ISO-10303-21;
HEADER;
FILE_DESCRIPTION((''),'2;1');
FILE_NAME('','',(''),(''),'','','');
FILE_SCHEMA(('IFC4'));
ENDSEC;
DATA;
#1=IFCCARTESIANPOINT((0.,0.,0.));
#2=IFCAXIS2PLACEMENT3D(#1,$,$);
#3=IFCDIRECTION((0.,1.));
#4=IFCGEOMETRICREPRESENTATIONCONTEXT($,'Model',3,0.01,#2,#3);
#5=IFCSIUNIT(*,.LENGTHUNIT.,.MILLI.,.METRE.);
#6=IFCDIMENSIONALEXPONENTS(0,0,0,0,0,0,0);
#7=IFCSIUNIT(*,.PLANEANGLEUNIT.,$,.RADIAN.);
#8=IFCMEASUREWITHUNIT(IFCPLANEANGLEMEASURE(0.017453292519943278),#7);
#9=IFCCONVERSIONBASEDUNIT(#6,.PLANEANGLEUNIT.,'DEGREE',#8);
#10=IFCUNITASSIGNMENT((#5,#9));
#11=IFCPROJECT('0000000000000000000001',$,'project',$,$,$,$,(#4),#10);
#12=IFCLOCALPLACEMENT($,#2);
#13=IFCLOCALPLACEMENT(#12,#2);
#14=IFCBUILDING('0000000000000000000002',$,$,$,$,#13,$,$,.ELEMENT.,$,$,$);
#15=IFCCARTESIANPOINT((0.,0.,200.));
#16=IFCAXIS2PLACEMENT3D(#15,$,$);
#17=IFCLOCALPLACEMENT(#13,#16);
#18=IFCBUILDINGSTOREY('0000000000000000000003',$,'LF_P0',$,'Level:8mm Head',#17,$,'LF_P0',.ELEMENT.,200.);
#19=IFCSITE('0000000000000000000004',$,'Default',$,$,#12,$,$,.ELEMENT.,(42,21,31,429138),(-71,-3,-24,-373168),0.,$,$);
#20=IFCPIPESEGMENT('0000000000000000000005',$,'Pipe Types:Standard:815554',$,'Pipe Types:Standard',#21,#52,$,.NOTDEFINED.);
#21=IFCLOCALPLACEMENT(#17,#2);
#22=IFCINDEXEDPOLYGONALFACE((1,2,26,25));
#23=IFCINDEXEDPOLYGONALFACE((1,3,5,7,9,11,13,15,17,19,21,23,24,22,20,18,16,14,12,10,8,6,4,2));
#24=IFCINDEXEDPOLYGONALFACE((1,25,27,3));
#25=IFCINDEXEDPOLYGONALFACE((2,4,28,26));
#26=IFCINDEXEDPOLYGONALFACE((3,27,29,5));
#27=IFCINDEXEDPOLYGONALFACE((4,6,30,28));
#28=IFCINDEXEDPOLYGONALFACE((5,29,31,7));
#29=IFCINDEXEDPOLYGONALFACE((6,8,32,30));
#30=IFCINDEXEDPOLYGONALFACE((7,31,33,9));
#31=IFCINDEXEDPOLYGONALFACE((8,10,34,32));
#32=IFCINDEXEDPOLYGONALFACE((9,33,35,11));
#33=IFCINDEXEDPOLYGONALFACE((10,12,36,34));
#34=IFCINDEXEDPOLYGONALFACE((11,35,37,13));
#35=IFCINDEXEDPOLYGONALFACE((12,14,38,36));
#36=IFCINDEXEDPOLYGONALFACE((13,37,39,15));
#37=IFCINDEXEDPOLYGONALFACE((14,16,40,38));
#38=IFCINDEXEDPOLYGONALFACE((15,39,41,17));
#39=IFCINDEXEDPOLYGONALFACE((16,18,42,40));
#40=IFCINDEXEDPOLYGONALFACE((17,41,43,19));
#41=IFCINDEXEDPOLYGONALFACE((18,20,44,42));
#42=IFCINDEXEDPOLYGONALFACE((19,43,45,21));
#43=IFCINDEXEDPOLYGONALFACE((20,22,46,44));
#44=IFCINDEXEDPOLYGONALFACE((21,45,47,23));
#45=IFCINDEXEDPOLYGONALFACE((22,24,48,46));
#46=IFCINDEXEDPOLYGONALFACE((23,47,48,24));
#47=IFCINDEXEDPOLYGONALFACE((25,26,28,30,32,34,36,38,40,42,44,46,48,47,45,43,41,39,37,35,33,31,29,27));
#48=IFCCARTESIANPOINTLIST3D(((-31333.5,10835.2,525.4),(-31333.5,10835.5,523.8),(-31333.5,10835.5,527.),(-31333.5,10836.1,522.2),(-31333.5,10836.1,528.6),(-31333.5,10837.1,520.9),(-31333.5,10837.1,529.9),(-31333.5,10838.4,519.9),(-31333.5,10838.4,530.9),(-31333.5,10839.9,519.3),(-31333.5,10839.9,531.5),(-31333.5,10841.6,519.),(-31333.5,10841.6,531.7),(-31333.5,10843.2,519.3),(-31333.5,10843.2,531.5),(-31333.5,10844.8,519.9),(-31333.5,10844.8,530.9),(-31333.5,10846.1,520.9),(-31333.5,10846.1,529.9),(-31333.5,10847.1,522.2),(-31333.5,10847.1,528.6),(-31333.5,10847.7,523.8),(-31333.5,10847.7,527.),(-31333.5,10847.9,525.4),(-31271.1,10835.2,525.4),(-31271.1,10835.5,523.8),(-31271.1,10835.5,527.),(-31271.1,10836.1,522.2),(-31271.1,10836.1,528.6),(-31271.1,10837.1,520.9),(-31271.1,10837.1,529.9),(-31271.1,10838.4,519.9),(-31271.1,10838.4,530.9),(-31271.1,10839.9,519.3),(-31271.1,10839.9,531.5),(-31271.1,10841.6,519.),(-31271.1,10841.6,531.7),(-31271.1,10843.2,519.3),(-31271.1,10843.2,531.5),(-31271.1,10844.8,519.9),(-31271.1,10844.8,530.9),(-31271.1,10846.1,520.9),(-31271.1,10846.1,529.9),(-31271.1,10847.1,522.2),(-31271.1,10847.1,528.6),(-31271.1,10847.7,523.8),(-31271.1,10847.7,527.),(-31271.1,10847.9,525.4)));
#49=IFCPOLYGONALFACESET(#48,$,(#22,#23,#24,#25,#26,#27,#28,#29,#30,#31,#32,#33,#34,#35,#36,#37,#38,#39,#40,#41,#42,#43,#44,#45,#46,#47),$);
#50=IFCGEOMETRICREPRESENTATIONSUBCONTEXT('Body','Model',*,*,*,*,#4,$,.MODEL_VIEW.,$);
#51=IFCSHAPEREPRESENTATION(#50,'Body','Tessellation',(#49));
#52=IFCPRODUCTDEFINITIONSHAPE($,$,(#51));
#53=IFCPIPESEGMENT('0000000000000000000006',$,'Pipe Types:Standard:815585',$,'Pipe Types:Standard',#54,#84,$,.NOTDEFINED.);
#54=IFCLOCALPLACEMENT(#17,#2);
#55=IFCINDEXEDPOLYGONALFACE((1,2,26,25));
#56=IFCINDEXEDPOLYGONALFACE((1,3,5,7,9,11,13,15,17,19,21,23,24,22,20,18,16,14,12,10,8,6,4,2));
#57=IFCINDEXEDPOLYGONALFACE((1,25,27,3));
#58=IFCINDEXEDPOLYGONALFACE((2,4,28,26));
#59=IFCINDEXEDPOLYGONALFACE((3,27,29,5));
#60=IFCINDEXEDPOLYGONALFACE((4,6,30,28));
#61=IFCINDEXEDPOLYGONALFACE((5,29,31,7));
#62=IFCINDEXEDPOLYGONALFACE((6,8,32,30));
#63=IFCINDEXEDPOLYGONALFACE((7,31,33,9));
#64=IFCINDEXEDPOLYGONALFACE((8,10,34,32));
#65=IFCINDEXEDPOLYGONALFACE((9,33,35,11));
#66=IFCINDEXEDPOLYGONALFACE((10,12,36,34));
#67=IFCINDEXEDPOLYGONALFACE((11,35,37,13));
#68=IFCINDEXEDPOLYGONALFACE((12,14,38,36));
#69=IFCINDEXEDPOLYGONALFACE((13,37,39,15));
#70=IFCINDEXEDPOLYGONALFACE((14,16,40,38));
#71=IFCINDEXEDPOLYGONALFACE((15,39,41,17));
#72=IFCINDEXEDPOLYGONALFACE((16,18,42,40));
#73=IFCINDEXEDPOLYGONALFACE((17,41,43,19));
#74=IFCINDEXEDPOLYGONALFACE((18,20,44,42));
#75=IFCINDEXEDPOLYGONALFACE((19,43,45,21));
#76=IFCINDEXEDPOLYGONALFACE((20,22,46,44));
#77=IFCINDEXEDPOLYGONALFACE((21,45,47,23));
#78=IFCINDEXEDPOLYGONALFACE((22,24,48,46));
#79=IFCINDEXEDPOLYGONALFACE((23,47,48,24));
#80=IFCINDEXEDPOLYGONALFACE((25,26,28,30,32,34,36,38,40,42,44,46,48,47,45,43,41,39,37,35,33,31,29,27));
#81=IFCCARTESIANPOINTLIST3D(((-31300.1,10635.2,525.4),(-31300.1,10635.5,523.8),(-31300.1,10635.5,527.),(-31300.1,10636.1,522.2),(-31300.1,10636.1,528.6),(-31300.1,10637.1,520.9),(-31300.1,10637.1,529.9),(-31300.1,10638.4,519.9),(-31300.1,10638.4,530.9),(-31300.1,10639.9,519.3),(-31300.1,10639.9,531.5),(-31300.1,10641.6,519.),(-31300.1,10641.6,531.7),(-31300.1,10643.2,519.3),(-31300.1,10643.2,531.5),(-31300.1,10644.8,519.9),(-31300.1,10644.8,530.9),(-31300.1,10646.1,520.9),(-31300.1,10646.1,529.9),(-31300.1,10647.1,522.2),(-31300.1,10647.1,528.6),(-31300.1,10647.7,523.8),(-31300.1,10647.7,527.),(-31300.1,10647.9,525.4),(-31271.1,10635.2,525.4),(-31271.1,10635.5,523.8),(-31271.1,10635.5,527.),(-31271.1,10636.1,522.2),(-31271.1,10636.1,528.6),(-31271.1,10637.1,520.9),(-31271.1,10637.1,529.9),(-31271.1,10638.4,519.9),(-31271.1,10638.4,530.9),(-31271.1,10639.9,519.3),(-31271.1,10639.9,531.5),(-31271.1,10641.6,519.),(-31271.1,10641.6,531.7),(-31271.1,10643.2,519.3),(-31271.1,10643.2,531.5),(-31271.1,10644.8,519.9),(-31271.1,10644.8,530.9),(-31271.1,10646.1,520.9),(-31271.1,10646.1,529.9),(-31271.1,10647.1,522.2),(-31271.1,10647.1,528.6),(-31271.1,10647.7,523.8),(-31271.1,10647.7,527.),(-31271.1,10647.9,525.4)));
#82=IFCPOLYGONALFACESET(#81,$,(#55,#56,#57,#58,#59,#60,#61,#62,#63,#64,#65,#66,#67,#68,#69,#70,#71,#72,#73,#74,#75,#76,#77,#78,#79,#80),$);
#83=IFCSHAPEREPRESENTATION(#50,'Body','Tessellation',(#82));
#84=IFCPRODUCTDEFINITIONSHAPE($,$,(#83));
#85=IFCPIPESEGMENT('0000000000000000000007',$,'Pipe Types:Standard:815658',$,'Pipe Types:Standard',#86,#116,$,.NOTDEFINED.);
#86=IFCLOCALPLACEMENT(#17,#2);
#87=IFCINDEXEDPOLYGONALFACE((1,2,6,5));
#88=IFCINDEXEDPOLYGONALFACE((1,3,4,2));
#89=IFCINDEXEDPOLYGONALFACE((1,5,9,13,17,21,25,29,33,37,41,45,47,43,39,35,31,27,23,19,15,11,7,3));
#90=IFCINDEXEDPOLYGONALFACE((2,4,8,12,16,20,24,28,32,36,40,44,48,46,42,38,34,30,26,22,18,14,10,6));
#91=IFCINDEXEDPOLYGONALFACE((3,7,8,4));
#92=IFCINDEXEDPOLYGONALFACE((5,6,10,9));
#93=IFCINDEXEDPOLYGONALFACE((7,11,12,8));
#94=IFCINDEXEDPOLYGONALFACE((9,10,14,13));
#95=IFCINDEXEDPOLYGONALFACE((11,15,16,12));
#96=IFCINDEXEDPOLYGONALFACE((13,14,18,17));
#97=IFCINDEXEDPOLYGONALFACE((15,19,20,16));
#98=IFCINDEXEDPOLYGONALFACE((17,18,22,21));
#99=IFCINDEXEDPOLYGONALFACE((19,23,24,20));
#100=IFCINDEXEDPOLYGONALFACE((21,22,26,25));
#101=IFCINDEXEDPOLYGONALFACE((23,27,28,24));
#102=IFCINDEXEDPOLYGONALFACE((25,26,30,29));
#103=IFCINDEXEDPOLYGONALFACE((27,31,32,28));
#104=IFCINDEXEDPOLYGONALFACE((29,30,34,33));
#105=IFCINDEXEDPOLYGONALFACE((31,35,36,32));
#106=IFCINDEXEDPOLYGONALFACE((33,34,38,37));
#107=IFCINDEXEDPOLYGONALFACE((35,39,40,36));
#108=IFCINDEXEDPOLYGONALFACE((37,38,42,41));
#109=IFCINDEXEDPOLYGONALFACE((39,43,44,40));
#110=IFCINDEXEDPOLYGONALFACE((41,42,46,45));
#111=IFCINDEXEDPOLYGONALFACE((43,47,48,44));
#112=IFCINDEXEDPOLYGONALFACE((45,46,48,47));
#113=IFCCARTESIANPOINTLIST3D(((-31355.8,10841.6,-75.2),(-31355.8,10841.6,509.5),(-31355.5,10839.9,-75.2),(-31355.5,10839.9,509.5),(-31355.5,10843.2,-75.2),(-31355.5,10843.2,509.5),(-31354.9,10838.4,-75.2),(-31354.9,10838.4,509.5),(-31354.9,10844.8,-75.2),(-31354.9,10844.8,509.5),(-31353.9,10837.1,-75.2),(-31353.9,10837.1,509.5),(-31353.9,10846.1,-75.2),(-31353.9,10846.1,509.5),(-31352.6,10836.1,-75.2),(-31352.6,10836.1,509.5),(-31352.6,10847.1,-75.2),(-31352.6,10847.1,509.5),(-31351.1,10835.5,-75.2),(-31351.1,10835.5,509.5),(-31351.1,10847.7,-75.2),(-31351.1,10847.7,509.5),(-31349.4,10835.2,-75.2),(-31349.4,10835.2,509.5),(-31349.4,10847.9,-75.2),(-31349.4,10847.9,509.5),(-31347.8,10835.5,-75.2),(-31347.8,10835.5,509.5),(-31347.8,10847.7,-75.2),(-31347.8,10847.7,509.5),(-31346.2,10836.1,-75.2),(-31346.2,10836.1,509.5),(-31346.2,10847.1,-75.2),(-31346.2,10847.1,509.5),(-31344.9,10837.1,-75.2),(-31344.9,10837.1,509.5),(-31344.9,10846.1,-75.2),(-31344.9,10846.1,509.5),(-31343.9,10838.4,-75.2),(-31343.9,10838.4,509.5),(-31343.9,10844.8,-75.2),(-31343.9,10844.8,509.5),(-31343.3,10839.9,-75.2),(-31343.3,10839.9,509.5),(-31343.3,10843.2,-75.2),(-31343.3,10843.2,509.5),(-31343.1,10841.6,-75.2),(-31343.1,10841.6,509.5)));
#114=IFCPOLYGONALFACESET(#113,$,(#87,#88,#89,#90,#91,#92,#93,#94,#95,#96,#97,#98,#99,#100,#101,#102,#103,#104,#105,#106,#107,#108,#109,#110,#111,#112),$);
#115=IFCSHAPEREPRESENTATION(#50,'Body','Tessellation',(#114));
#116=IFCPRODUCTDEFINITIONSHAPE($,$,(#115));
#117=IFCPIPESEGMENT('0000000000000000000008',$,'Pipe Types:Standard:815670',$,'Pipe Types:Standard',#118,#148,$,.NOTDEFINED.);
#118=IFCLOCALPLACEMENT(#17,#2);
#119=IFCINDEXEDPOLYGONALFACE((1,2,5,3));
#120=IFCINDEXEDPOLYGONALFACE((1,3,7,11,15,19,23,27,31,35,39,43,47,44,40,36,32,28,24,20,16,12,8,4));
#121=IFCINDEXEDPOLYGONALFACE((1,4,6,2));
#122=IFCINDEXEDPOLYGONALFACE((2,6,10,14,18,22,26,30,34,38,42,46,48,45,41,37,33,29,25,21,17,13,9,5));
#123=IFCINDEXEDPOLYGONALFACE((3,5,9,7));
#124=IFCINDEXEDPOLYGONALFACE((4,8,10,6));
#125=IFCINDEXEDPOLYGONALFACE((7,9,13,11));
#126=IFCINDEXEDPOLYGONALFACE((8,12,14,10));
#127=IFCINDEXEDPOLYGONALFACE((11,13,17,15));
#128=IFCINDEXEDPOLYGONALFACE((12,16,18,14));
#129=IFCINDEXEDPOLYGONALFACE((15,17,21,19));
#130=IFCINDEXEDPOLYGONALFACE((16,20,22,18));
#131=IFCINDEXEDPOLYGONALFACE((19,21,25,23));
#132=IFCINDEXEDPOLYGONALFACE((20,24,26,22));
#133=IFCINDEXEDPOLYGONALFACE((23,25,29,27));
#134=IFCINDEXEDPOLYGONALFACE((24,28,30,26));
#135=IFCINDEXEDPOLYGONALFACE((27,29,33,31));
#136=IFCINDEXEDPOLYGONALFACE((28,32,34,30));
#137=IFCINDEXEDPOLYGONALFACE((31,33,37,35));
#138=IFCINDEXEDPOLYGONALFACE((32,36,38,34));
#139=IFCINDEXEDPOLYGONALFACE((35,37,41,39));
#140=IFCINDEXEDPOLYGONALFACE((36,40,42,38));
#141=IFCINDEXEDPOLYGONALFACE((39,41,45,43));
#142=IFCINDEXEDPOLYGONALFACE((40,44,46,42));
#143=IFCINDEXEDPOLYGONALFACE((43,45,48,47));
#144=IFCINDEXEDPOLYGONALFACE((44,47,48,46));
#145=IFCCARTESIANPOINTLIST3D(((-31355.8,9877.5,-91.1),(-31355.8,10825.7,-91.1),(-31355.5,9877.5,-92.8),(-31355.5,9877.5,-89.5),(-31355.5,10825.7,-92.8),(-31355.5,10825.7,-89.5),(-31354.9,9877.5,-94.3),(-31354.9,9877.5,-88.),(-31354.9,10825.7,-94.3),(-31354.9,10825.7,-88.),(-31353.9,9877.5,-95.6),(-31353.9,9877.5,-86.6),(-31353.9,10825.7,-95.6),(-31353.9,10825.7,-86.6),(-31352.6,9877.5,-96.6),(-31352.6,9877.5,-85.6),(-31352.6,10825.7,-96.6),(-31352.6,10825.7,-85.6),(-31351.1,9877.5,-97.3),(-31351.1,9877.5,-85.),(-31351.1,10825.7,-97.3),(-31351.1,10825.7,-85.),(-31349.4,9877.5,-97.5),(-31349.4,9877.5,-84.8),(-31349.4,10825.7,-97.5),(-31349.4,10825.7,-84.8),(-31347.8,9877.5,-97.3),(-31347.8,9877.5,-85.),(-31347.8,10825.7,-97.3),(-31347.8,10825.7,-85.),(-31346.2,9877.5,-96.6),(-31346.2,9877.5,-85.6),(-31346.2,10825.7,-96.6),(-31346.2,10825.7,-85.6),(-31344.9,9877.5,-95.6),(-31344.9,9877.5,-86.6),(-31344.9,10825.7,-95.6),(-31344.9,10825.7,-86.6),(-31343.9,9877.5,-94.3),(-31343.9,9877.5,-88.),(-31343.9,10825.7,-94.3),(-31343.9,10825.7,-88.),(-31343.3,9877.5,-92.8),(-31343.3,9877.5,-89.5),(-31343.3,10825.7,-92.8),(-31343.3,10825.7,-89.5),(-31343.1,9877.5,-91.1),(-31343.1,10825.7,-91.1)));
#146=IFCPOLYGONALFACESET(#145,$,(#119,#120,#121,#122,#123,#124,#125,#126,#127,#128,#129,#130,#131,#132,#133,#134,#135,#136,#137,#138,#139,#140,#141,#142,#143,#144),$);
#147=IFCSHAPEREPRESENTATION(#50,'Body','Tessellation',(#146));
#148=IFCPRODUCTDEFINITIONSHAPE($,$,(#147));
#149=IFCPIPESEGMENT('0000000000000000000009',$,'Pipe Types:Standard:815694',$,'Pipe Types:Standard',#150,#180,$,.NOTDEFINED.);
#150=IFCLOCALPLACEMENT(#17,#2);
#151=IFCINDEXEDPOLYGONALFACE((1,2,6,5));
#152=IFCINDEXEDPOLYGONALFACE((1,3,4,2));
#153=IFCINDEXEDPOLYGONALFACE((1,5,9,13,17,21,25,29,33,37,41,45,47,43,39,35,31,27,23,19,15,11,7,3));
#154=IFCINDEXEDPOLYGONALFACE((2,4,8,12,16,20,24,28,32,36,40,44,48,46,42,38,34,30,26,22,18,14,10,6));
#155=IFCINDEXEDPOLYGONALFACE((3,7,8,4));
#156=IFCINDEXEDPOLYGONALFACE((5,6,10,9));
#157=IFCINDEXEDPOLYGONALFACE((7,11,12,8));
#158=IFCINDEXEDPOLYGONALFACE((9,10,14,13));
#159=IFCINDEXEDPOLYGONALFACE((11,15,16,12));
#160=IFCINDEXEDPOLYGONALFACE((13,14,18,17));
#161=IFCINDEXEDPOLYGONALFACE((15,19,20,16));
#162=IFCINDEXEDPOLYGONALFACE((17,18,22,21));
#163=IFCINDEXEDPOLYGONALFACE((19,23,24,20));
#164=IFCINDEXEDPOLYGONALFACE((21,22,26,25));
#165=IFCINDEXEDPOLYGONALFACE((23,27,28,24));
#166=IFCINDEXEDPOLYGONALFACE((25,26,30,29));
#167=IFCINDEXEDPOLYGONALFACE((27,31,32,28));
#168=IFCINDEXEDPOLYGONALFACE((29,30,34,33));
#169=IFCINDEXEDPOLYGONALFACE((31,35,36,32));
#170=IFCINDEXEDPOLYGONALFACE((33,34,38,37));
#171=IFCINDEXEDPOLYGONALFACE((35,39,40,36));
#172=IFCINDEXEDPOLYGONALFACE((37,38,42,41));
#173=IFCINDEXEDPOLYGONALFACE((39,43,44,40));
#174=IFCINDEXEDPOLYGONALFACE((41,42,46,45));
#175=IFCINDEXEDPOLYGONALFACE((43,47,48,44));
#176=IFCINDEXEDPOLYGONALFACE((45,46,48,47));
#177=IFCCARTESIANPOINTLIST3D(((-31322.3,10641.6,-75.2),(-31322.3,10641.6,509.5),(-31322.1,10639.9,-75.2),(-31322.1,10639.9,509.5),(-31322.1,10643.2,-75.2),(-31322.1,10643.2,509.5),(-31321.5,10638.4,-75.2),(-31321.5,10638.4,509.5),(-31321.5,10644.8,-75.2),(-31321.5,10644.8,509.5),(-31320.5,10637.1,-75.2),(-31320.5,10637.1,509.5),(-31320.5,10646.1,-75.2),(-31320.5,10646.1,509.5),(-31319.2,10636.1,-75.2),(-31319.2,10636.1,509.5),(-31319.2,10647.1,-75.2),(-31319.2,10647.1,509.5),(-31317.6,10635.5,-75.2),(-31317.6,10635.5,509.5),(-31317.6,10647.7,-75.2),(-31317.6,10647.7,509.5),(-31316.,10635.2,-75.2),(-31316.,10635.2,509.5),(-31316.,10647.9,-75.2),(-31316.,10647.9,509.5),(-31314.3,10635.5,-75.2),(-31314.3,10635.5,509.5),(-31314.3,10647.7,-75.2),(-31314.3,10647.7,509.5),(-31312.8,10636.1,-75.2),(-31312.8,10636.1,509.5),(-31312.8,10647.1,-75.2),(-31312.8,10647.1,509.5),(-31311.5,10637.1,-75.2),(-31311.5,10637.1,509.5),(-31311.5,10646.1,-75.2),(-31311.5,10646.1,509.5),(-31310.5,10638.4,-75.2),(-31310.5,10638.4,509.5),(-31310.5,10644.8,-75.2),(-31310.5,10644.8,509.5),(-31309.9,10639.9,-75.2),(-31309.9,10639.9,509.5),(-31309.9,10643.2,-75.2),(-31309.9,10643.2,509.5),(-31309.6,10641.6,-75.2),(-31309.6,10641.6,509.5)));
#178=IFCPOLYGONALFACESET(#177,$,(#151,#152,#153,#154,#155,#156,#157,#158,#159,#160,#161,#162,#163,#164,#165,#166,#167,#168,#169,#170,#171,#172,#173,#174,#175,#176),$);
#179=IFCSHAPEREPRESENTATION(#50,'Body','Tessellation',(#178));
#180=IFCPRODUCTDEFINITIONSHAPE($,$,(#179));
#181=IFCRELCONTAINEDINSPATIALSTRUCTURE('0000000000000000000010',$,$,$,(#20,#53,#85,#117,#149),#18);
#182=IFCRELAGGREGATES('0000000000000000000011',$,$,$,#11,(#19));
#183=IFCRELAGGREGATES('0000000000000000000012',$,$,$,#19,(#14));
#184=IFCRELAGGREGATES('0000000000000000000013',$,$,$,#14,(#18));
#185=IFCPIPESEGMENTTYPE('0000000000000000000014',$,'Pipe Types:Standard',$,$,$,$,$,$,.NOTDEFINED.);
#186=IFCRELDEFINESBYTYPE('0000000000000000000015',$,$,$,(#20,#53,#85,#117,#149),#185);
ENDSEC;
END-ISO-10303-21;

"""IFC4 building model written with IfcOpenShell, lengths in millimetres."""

from ifc_helpers import new_model, entity, si_unit, converted_unit, direction, frame, origin, place, context, subcontext, project, spatial, arc, indexed_curve, outline, extrude, type_object, element, save


model = new_model("IFC4")

# Units and contexts
model_context = context("Model", 3, precision=0.01, world=origin(), true_north=direction((0.0, 1.0)))
body_context = subcontext(model_context, "Body", "Model", "MODEL_VIEW")
ifc_project = project(units=[si_unit("LENGTHUNIT", "METRE", prefix="MILLI"), converted_unit("PLANEANGLEUNIT", "DEGREE", entity("IfcPlaneAngleMeasure", 0.017453292519943278), si_unit("PLANEANGLEUNIT", "RADIAN"), dimensions=[0, 0, 0, 0, 0, 0, 0])], contexts=[model_context])

# Site, building, storey
site_placement = place(None, origin())
site = spatial("IfcSite", under=ifc_project, at=site_placement, Name="Default", CompositionType="ELEMENT", RefLatitude=(42, 21, 31, 429138), RefLongitude=(-71, -3, -24, -373168), RefElevation=0.0)
building_placement = place(site_placement, origin())
building = spatial("IfcBuilding", under=site, at=building_placement, CompositionType="ELEMENT")
storey_placement = place(building_placement, frame((0.0, 0.0, 200.0)))
storey = spatial("IfcBuildingStorey", under=building, at=storey_placement, Name="LF_P0", ObjectType="Level:8mm Head", LongName="LF_P0", CompositionType="ELEMENT", Elevation=200.0)

# Pipe segments
pipe_segment_type = type_object("IfcPipeSegmentType", Name="Pipe Types:Standard", PredefinedType="NOTDEFINED")
pipe_segment_1_placement = place(storey_placement, origin())
element("IfcPipeSegment", 1, at=pipe_segment_1_placement, inside=storey, type_object=pipe_segment_type, Name="Pipe Types:Standard:815554", ObjectType="Pipe Types:Standard", PredefinedType="NOTDEFINED", context=body_context, shape_type="SweptSolid", body=[
    extrude(outline(indexed_curve([(6.4, 0.0), (4.5, 4.5), (0.0, 6.4), (-4.5, 4.5), (-6.4, 0.0), (-4.5, -4.5), (0.0, -6.4), (4.5, -4.5)], segments=[arc(1, 2, 3), arc(3, 4, 5), arc(5, 6, 7), arc(7, 8, 1)], self_intersect=False)), frame((-31333.5, 10841.6, 525.4), z_axis=(1.0, 0.0, 0.0), x_axis=(0.0, 1.0, 0.0)), (0.0, 0.0, 1.0), 62.4),
])
pipe_segment_2_placement = place(storey_placement, origin())
element("IfcPipeSegment", 2, at=pipe_segment_2_placement, inside=storey, type_object=pipe_segment_type, Name="Pipe Types:Standard:815585", ObjectType="Pipe Types:Standard", PredefinedType="NOTDEFINED", context=body_context, shape_type="SweptSolid", body=[
    extrude(outline(indexed_curve([(6.3, 0.0), (4.5, 4.5), (0.0, 6.4), (-4.5, 4.5), (-6.4, 0.0), (-4.5, -4.5), (0.0, -6.4), (4.5, -4.5)], segments=[arc(1, 2, 3), arc(3, 4, 5), arc(5, 6, 7), arc(7, 8, 1)], self_intersect=False)), frame((-31300.1, 10641.6, 525.4), z_axis=(1.0, 0.0, 0.0), x_axis=(0.0, 1.0, 0.0)), (0.0, 0.0, 1.0), 29.0),
])
pipe_segment_3_placement = place(storey_placement, origin())
element("IfcPipeSegment", 3, at=pipe_segment_3_placement, inside=storey, type_object=pipe_segment_type, Name="Pipe Types:Standard:815658", ObjectType="Pipe Types:Standard", PredefinedType="NOTDEFINED", context=body_context, shape_type="SweptSolid", body=[
    extrude(outline(indexed_curve([(6.3, 0.0), (4.5, 4.5), (0.0, 6.4), (-4.5, 4.5), (-6.3, 0.0), (-4.5, -4.5), (0.0, -6.3), (4.5, -4.5)], segments=[arc(1, 2, 3), arc(3, 4, 5), arc(5, 6, 7), arc(7, 8, 1)], self_intersect=False)), frame((-31349.4, 10841.6, -75.2)), (0.0, 0.0, 1.0), 584.7),
])
pipe_segment_4_placement = place(storey_placement, origin())
element("IfcPipeSegment", 4, at=pipe_segment_4_placement, inside=storey, type_object=pipe_segment_type, Name="Pipe Types:Standard:815670", ObjectType="Pipe Types:Standard", PredefinedType="NOTDEFINED", context=body_context, shape_type="SweptSolid", body=[
    extrude(outline(indexed_curve([(6.4, 0.0), (4.5, 4.5), (0.0, 6.3), (-4.5, 4.5), (-6.3, 0.0), (-4.5, -4.5), (0.0, -6.4), (4.5, -4.5)], segments=[arc(1, 2, 3), arc(3, 4, 5), arc(5, 6, 7), arc(7, 8, 1)], self_intersect=False)), frame((-31349.4, 9877.5, -91.1), z_axis=(0.0, 1.0, 0.0), x_axis=(-1.0, 0.0, 0.0)), (0.0, 0.0, 1.0), 948.2),
])
pipe_segment_5_placement = place(storey_placement, origin())
element("IfcPipeSegment", 5, at=pipe_segment_5_placement, inside=storey, type_object=pipe_segment_type, Name="Pipe Types:Standard:815694", ObjectType="Pipe Types:Standard", PredefinedType="NOTDEFINED", context=body_context, shape_type="SweptSolid", body=[
    extrude(outline(indexed_curve([(6.3, 0.0), (4.5, 4.5), (0.0, 6.4), (-4.5, 4.5), (-6.3, 0.0), (-4.5, -4.5), (0.0, -6.4), (4.5, -4.5)], segments=[arc(1, 2, 3), arc(3, 4, 5), arc(5, 6, 7), arc(7, 8, 1)], self_intersect=False)), frame((-31316.0, 10641.6, -75.2)), (0.0, 0.0, 1.0), 584.7),
])

save(model, "model.ifc")
